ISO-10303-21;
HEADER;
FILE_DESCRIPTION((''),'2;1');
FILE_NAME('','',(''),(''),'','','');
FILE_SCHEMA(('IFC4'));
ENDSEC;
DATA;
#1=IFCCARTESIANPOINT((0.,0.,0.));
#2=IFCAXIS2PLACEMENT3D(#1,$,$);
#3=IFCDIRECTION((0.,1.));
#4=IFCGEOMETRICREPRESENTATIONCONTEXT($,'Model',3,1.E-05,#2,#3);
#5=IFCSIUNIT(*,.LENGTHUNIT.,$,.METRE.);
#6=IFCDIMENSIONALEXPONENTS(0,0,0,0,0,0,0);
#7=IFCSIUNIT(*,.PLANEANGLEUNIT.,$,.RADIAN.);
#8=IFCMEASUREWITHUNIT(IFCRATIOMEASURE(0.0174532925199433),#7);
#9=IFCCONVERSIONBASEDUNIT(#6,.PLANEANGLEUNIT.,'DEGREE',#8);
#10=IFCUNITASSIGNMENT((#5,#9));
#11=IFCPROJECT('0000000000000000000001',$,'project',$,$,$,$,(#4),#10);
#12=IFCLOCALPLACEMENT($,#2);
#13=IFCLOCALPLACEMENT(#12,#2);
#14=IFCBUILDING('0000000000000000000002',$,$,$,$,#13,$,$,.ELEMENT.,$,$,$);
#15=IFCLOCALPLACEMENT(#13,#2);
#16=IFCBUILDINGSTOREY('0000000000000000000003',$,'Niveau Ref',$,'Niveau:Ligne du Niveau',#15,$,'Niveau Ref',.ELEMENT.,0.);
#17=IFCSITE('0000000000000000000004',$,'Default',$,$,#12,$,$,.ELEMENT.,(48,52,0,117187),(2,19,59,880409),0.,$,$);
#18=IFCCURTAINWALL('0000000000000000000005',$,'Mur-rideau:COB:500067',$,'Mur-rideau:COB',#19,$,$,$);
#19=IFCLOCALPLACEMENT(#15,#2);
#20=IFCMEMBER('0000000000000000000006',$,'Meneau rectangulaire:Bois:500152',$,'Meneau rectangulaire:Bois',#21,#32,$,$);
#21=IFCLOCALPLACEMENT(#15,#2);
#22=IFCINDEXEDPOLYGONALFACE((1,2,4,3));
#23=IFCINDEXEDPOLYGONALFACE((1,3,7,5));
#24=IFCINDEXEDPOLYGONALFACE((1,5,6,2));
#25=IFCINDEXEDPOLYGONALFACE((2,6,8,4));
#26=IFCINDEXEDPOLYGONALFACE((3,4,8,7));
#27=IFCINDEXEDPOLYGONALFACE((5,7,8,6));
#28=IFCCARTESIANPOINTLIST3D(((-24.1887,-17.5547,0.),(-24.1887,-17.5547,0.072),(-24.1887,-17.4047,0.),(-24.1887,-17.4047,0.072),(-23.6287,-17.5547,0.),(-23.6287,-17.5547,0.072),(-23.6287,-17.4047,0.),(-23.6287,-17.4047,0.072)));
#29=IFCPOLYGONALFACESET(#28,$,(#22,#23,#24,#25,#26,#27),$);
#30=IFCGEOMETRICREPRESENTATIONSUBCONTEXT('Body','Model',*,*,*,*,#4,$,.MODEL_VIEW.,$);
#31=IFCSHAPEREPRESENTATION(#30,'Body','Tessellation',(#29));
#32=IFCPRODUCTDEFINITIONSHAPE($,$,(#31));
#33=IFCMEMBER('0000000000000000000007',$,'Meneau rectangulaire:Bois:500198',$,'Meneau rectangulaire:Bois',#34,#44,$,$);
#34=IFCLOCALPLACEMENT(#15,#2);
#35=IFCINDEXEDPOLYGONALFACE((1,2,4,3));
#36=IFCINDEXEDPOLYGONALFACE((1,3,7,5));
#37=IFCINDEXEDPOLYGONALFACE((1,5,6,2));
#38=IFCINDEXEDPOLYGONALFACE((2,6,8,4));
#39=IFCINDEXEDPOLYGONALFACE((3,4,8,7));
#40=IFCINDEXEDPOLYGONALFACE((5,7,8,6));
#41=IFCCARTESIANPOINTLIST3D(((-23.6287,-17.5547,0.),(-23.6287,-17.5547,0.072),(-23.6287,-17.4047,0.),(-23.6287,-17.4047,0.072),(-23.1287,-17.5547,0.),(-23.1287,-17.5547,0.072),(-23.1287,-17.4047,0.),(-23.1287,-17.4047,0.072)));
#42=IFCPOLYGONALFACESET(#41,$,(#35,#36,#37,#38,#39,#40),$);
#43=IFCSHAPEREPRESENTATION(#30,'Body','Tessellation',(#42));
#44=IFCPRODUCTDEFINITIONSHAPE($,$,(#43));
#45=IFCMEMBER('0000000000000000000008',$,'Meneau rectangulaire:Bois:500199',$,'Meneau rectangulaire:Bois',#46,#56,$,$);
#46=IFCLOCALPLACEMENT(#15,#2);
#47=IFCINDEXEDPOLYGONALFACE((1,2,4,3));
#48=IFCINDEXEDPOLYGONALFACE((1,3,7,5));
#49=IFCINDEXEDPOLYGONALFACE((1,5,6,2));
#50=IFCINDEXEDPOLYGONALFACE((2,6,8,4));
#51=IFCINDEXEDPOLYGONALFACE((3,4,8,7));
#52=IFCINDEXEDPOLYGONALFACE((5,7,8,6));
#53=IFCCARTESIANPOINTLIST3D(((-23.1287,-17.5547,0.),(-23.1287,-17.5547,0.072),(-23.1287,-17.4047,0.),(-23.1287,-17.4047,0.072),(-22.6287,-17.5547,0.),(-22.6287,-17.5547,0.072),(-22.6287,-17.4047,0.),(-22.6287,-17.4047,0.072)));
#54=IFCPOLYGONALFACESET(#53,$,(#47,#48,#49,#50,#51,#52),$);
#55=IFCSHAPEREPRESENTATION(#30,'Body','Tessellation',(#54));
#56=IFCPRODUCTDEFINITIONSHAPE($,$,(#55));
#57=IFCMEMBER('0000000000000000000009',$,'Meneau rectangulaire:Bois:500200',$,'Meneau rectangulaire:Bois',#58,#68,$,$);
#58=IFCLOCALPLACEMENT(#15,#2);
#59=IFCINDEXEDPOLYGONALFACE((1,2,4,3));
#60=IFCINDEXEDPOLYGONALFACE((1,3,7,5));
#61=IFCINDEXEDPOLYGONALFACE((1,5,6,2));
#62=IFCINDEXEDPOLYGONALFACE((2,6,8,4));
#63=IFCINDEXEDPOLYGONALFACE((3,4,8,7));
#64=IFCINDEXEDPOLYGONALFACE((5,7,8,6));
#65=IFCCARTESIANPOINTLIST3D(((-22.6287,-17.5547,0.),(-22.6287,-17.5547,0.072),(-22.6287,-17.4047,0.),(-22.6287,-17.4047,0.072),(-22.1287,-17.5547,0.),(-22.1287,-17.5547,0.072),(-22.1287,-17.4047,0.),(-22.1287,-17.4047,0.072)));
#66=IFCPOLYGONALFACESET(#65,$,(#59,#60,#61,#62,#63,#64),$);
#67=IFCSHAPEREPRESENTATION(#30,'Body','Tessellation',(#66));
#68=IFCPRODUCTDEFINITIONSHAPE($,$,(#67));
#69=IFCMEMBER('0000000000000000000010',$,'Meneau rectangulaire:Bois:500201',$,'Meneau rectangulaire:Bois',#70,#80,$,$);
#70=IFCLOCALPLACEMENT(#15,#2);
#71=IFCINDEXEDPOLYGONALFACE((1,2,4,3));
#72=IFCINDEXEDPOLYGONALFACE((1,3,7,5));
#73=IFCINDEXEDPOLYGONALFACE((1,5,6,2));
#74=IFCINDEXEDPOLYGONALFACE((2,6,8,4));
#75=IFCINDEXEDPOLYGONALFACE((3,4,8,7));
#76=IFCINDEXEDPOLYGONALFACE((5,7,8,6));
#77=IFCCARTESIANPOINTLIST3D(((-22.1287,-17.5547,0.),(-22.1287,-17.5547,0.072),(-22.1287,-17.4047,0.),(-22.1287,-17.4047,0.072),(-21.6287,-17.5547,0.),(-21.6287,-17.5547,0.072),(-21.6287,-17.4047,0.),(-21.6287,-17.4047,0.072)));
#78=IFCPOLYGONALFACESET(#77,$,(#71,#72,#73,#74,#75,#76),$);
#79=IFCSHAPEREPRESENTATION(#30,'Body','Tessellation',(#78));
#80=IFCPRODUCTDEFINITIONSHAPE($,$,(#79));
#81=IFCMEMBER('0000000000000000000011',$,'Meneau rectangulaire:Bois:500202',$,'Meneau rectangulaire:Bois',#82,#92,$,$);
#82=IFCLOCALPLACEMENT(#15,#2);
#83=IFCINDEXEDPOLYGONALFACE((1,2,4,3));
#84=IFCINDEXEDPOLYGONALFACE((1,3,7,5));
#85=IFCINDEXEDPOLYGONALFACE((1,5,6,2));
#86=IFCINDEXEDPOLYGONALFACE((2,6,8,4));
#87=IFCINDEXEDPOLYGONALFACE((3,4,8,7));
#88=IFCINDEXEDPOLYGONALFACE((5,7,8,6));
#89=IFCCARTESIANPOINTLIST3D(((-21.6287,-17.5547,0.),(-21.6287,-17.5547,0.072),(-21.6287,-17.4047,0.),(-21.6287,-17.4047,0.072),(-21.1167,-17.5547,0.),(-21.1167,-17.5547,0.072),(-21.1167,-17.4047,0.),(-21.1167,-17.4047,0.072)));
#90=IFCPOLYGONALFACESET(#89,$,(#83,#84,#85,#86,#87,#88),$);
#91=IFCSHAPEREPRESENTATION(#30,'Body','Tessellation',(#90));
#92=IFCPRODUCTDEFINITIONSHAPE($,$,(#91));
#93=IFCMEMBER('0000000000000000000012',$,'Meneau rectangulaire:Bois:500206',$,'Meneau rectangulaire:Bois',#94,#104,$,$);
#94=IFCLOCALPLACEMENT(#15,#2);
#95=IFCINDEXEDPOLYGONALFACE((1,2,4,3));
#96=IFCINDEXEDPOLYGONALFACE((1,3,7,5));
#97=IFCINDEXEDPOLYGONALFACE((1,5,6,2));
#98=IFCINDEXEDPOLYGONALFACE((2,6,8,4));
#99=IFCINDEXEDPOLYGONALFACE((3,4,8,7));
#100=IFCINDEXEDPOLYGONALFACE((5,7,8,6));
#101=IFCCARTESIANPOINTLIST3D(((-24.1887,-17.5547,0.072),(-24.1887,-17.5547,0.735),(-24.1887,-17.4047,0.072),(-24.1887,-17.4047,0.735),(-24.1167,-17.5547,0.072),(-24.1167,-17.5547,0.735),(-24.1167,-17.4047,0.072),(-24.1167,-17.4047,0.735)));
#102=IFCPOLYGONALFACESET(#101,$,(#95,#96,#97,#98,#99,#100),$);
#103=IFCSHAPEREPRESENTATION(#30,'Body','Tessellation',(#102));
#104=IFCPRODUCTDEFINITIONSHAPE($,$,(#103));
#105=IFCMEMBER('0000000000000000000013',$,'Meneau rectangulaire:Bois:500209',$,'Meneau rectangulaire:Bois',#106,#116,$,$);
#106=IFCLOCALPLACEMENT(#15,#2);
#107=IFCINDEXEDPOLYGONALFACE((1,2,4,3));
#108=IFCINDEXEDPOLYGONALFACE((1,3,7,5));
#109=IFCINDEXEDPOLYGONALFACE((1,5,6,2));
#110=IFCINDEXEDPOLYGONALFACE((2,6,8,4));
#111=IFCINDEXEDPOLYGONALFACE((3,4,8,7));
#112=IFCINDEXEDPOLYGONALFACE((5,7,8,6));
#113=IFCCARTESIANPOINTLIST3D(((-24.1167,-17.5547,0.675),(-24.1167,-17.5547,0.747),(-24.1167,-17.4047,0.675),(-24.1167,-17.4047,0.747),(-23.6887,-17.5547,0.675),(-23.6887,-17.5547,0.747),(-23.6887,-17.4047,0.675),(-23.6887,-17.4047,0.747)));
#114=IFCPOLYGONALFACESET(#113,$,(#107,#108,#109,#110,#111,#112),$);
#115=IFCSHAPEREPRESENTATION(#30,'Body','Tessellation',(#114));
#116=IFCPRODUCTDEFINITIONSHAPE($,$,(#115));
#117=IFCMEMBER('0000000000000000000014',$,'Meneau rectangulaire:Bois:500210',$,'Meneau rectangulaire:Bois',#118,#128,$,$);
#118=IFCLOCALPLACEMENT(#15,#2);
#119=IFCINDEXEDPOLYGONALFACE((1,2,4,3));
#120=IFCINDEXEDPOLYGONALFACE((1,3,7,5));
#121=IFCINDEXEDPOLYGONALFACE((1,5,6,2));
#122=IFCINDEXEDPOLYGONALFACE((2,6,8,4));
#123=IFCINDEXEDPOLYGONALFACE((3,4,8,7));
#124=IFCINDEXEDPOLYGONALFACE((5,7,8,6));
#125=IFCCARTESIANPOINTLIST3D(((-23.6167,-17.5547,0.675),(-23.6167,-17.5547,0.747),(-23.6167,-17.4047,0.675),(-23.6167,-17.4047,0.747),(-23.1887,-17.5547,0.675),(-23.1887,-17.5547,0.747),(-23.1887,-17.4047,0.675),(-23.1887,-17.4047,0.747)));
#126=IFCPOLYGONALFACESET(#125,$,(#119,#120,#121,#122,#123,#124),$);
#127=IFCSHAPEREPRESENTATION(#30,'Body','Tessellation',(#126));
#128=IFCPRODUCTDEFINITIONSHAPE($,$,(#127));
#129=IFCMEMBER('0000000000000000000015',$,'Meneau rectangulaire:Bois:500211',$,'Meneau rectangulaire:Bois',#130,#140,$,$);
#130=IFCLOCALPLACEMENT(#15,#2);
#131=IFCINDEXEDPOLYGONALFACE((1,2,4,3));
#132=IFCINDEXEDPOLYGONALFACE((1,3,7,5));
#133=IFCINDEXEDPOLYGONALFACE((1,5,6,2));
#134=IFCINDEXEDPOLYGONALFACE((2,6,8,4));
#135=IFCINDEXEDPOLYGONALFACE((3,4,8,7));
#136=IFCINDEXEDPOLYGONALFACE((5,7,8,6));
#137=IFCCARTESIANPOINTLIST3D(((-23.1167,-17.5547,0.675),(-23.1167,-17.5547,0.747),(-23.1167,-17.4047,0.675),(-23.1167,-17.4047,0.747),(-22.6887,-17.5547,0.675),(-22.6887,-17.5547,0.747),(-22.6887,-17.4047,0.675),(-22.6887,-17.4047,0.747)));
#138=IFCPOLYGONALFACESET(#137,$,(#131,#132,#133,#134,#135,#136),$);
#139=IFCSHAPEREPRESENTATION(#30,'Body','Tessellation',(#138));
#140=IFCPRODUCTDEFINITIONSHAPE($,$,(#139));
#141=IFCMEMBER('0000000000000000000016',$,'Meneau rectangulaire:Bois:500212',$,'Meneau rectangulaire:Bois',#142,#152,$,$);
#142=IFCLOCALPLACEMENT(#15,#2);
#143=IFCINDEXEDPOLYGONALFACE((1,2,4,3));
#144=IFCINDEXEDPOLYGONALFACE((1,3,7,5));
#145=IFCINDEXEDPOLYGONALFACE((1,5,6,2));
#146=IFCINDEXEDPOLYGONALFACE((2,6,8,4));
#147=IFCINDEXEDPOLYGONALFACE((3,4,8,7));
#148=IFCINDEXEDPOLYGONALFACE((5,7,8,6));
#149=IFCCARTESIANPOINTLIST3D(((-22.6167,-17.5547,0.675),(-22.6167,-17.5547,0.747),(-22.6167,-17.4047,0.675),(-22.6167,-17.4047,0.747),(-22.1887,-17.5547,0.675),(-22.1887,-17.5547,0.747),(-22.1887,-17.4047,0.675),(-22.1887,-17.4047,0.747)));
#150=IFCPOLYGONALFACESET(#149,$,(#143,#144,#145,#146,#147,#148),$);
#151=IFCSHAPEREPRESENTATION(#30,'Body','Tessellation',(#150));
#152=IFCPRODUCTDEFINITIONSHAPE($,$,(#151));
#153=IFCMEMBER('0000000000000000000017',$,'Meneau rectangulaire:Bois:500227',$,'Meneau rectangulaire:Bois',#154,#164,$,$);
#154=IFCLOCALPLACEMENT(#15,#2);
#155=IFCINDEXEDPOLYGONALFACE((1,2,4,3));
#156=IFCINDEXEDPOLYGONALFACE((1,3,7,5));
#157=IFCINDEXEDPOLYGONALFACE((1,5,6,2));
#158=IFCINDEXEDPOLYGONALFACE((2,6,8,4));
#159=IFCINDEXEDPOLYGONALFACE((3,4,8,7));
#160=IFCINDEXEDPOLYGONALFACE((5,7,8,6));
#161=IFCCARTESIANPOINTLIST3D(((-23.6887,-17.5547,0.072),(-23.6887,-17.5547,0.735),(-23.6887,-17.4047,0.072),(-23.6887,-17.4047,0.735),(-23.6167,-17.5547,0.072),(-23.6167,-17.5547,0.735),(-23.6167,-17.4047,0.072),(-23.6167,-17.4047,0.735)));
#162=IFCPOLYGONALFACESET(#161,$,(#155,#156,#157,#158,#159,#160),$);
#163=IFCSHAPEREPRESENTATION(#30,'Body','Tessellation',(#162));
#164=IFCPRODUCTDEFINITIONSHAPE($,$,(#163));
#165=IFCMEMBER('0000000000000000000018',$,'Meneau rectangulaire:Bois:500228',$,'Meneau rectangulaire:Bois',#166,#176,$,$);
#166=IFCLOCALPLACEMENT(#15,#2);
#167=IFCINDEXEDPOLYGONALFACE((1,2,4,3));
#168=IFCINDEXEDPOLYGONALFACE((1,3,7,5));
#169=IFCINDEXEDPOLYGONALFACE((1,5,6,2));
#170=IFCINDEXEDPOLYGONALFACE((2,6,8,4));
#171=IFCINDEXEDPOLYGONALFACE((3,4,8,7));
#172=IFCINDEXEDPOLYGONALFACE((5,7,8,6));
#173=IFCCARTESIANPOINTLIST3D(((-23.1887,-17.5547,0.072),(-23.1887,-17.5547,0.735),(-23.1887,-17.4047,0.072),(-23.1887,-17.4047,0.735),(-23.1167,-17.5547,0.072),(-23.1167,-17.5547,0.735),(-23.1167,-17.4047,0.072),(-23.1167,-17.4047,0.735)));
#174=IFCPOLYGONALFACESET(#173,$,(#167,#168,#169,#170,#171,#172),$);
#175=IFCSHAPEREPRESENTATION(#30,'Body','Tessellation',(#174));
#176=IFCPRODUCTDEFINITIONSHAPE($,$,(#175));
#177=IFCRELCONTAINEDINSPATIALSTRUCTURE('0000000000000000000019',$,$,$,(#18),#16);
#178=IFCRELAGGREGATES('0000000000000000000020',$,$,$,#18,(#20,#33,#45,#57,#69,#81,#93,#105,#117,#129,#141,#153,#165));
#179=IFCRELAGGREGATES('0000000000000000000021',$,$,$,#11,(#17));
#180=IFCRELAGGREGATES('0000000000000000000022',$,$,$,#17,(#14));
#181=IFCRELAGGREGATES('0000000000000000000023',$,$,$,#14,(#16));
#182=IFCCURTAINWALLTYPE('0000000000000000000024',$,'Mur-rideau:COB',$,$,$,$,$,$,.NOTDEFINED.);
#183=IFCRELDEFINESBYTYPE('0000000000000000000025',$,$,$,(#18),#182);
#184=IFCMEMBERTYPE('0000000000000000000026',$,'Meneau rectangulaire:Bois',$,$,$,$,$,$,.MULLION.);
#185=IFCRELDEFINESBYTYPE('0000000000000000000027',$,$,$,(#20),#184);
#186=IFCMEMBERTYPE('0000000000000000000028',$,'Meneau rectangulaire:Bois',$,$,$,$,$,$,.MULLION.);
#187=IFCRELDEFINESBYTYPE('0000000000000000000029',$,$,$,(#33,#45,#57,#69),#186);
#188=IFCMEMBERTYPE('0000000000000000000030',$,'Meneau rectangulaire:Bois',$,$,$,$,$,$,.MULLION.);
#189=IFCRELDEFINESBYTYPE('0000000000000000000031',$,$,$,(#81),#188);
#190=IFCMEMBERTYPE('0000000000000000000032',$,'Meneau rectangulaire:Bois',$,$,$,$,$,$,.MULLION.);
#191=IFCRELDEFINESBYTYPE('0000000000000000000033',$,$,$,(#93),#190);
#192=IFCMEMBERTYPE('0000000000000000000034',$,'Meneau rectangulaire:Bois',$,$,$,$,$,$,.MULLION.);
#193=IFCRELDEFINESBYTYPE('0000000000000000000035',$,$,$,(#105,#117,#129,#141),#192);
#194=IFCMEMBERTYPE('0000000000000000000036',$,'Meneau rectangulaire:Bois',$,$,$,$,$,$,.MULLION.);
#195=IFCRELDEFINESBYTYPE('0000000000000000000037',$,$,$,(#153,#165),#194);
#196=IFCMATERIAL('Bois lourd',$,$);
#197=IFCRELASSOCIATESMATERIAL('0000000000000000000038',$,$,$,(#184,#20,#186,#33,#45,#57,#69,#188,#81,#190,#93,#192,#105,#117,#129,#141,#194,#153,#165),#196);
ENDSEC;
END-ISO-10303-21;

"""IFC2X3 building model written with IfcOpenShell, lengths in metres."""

from ifc_helpers import new_model, entity, si_unit, converted_unit, direction, frame, origin, origin_2d_with_axis, place, context, subcontext, project, spatial, rectangle, extrude, source, transform, mapped, material, type_object, type_shapes, element, aggregate, save


model = new_model("IFC2X3")

# Units and contexts
model_context = context("Model", 3, precision=1e-05, world=origin(), true_north=direction((0.0, 1.0)))
body_context = subcontext(model_context, "Body", "Model", "MODEL_VIEW")
ifc_project = project(units=[si_unit("LENGTHUNIT", "METRE"), converted_unit("PLANEANGLEUNIT", "DEGREE", entity("IfcRatioMeasure", 0.0174532925199433), si_unit("PLANEANGLEUNIT", "RADIAN"), dimensions=[0, 0, 0, 0, 0, 0, 0])], contexts=[model_context])

# Site, building, storey
site_placement = place(None, origin())
site = spatial("IfcSite", under=ifc_project, at=site_placement, Name="Default", CompositionType="ELEMENT", RefLatitude=(48, 52, 0, 117187), RefLongitude=(2, 19, 59, 880409), RefElevation=0.0)
building_placement = place(site_placement, origin())
building = spatial("IfcBuilding", under=site, at=building_placement, CompositionType="ELEMENT")
storey_placement = place(building_placement, origin())
storey = spatial("IfcBuildingStorey", under=building, at=storey_placement, Name="Niveau Ref", ObjectType="Niveau:Ligne du Niveau", LongName="Niveau Ref", CompositionType="ELEMENT", Elevation=0.0)

# Curtain wall, members
curtain_wall_type_1 = type_object("IfcCurtainWallType", Name="Mur-rideau:COB", PredefinedType="NOTDEFINED")
curtain_wall_1_placement = place(storey_placement, origin())
curtain_wall_1 = element("IfcCurtainWall", 1, at=curtain_wall_1_placement, inside=storey, type_object=curtain_wall_type_1, Name="Mur-rideau:COB:500067", ObjectType="Mur-rideau:COB")
ifc_material_1 = material(Name="Bois lourd")
member_type_1 = type_object("IfcMemberType", Name="Meneau rectangulaire:Bois", PredefinedType="MULLION", material=ifc_material_1)
shared_shape_1 = source(origin(), body_context, "Body", "SweptSolid", [
    extrude(rectangle(XDim=0.15, YDim=0.072, at=origin_2d_with_axis()), frame((-0.036, 0.0, -0.56), z_axis=(0.0, 0.0, 1.0), x_axis=(0.0, -1.0, 0.0)), (0.0, 0.0, 1.0), 0.56),
])
type_shapes(member_type_1, [shared_shape_1])
member_1_placement = place(storey_placement, frame((-24.1887, -17.4797, 0.0), z_axis=(-1.0, 0.0, 0.0), x_axis=(0.0, 0.0, -1.0)))
member_1 = element("IfcMember", 2, at=member_1_placement, type_object=member_type_1, material=ifc_material_1, Name="Meneau rectangulaire:Bois:500152", ObjectType="Meneau rectangulaire:Bois", context=body_context, shape_type="MappedRepresentation", body=[
    mapped(shared_shape_1, transform((0.0, 0.0, 0.0), scale=1.0)),
])
member_type_2 = type_object("IfcMemberType", Name="Meneau rectangulaire:Bois", PredefinedType="MULLION", material=ifc_material_1)
shared_shape_2 = source(origin(), body_context, "Body", "SweptSolid", [
    extrude(rectangle(XDim=0.15, YDim=0.072, at=origin_2d_with_axis()), frame((-0.036, 0.0, -0.5), z_axis=(0.0, 0.0, 1.0), x_axis=(0.0, -1.0, 0.0)), (0.0, 0.0, 1.0), 0.5),
])
type_shapes(member_type_2, [shared_shape_2])
member_2_placement = place(storey_placement, frame((-23.6287, -17.4797, 0.0), z_axis=(-1.0, 0.0, 0.0), x_axis=(0.0, 0.0, -1.0)))
member_2 = element("IfcMember", 3, at=member_2_placement, type_object=member_type_2, material=ifc_material_1, Name="Meneau rectangulaire:Bois:500198", ObjectType="Meneau rectangulaire:Bois", context=body_context, shape_type="MappedRepresentation", body=[
    mapped(shared_shape_2, transform((0.0, 0.0, 0.0), scale=1.0)),
])
member_3_placement = place(storey_placement, frame((-23.1287, -17.4797, 0.0), z_axis=(-1.0, 0.0, 0.0), x_axis=(0.0, 0.0, -1.0)))
member_3 = element("IfcMember", 4, at=member_3_placement, type_object=member_type_2, material=ifc_material_1, Name="Meneau rectangulaire:Bois:500199", ObjectType="Meneau rectangulaire:Bois", context=body_context, shape_type="MappedRepresentation", body=[
    mapped(shared_shape_2, transform((0.0, 0.0, 0.0), scale=1.0)),
])
member_4_placement = place(storey_placement, frame((-22.6287, -17.4797, 0.0), z_axis=(-1.0, 0.0, 0.0), x_axis=(0.0, 0.0, -1.0)))
member_4 = element("IfcMember", 5, at=member_4_placement, type_object=member_type_2, material=ifc_material_1, Name="Meneau rectangulaire:Bois:500200", ObjectType="Meneau rectangulaire:Bois", context=body_context, shape_type="MappedRepresentation", body=[
    mapped(shared_shape_2, transform((0.0, 0.0, 0.0), scale=1.0)),
])
member_5_placement = place(storey_placement, frame((-22.1287, -17.4797, 0.0), z_axis=(-1.0, 0.0, 0.0), x_axis=(0.0, 0.0, -1.0)))
member_5 = element("IfcMember", 6, at=member_5_placement, type_object=member_type_2, material=ifc_material_1, Name="Meneau rectangulaire:Bois:500201", ObjectType="Meneau rectangulaire:Bois", context=body_context, shape_type="MappedRepresentation", body=[
    mapped(shared_shape_2, transform((0.0, 0.0, 0.0), scale=1.0)),
])
member_type_3 = type_object("IfcMemberType", Name="Meneau rectangulaire:Bois", PredefinedType="MULLION", material=ifc_material_1)
shared_shape_3 = source(origin(), body_context, "Body", "SweptSolid", [
    extrude(rectangle(XDim=0.15, YDim=0.072, at=origin_2d_with_axis()), frame((-0.036, 0.0, -0.512), z_axis=(0.0, 0.0, 1.0), x_axis=(0.0, -1.0, 0.0)), (0.0, 0.0, 1.0), 0.512),
])
type_shapes(member_type_3, [shared_shape_3])
member_6_placement = place(storey_placement, frame((-21.6287, -17.4797, 0.0), z_axis=(-1.0, 0.0, 0.0), x_axis=(0.0, 0.0, -1.0)))
member_6 = element("IfcMember", 7, at=member_6_placement, type_object=member_type_3, material=ifc_material_1, Name="Meneau rectangulaire:Bois:500202", ObjectType="Meneau rectangulaire:Bois", context=body_context, shape_type="MappedRepresentation", body=[
    mapped(shared_shape_3, transform((0.0, 0.0, 0.0), scale=1.0)),
])
member_type_4 = type_object("IfcMemberType", Name="Meneau rectangulaire:Bois", PredefinedType="MULLION", material=ifc_material_1)
shared_shape_4 = source(origin(), body_context, "Body", "SweptSolid", [
    extrude(rectangle(XDim=0.15, YDim=0.072, at=origin_2d_with_axis()), frame((-0.036, 0.0, -0.663), z_axis=(0.0, 0.0, 1.0), x_axis=(0.0, -1.0, 0.0)), (0.0, 0.0, 1.0), 0.663),
])
type_shapes(member_type_4, [shared_shape_4])
member_7_placement = place(storey_placement, frame((-24.1887, -17.4797, 0.735), z_axis=(0.0, 0.0, 1.0), x_axis=(-1.0, 0.0, 0.0)))
member_7 = element("IfcMember", 8, at=member_7_placement, type_object=member_type_4, material=ifc_material_1, Name="Meneau rectangulaire:Bois:500206", ObjectType="Meneau rectangulaire:Bois", context=body_context, shape_type="MappedRepresentation", body=[
    mapped(shared_shape_4, transform((0.0, 0.0, 0.0), scale=1.0)),
])
member_type_5 = type_object("IfcMemberType", Name="Meneau rectangulaire:Bois", PredefinedType="MULLION", material=ifc_material_1)
shared_shape_5 = source(origin(), body_context, "Body", "SweptSolid", [
    extrude(rectangle(XDim=0.15, YDim=0.072, at=origin_2d_with_axis()), frame((-0.024, 0.0, -0.428), z_axis=(0.0, 0.0, 1.0), x_axis=(0.0, -1.0, 0.0)), (0.0, 0.0, 1.0), 0.428),
])
type_shapes(member_type_5, [shared_shape_5])
member_8_placement = place(storey_placement, frame((-23.6887, -17.4797, 0.735), z_axis=(1.0, 0.0, 0.0), x_axis=(0.0, 0.0, 1.0)))
member_8 = element("IfcMember", 9, at=member_8_placement, type_object=member_type_5, material=ifc_material_1, Name="Meneau rectangulaire:Bois:500209", ObjectType="Meneau rectangulaire:Bois", context=body_context, shape_type="MappedRepresentation", body=[
    mapped(shared_shape_5, transform((0.0, 0.0, 0.0), scale=1.0)),
])
member_9_placement = place(storey_placement, frame((-23.1887, -17.4797, 0.735), z_axis=(1.0, 0.0, 0.0), x_axis=(0.0, 0.0, 1.0)))
member_9 = element("IfcMember", 10, at=member_9_placement, type_object=member_type_5, material=ifc_material_1, Name="Meneau rectangulaire:Bois:500210", ObjectType="Meneau rectangulaire:Bois", context=body_context, shape_type="MappedRepresentation", body=[
    mapped(shared_shape_5, transform((0.0, 0.0, 0.0), scale=1.0)),
])
member_10_placement = place(storey_placement, frame((-22.6887, -17.4797, 0.735), z_axis=(1.0, 0.0, 0.0), x_axis=(0.0, 0.0, 1.0)))
member_10 = element("IfcMember", 11, at=member_10_placement, type_object=member_type_5, material=ifc_material_1, Name="Meneau rectangulaire:Bois:500211", ObjectType="Meneau rectangulaire:Bois", context=body_context, shape_type="MappedRepresentation", body=[
    mapped(shared_shape_5, transform((0.0, 0.0, 0.0), scale=1.0)),
])
member_11_placement = place(storey_placement, frame((-22.1887, -17.4797, 0.735), z_axis=(1.0, 0.0, 0.0), x_axis=(0.0, 0.0, 1.0)))
member_11 = element("IfcMember", 12, at=member_11_placement, type_object=member_type_5, material=ifc_material_1, Name="Meneau rectangulaire:Bois:500212", ObjectType="Meneau rectangulaire:Bois", context=body_context, shape_type="MappedRepresentation", body=[
    mapped(shared_shape_5, transform((0.0, 0.0, 0.0), scale=1.0)),
])
member_type_6 = type_object("IfcMemberType", Name="Meneau rectangulaire:Bois", PredefinedType="MULLION", material=ifc_material_1)
shared_shape_6 = source(origin(), body_context, "Body", "SweptSolid", [
    extrude(rectangle(XDim=0.15, YDim=0.072, at=origin_2d_with_axis()), frame((-0.024, 0.0, -0.663), z_axis=(0.0, 0.0, 1.0), x_axis=(0.0, -1.0, 0.0)), (0.0, 0.0, 1.0), 0.663),
])
type_shapes(member_type_6, [shared_shape_6])
member_12_placement = place(storey_placement, frame((-23.6287, -17.4797, 0.072), z_axis=(0.0, 0.0, -1.0), x_axis=(1.0, 0.0, 0.0)))
member_12 = element("IfcMember", 13, at=member_12_placement, type_object=member_type_6, material=ifc_material_1, Name="Meneau rectangulaire:Bois:500227", ObjectType="Meneau rectangulaire:Bois", context=body_context, shape_type="MappedRepresentation", body=[
    mapped(shared_shape_6, transform((0.0, 0.0, 0.0), scale=1.0)),
])
member_13_placement = place(storey_placement, frame((-23.1287, -17.4797, 0.072), z_axis=(0.0, 0.0, -1.0), x_axis=(1.0, 0.0, 0.0)))
member_13 = element("IfcMember", 14, at=member_13_placement, type_object=member_type_6, material=ifc_material_1, Name="Meneau rectangulaire:Bois:500228", ObjectType="Meneau rectangulaire:Bois", context=body_context, shape_type="MappedRepresentation", body=[
    mapped(shared_shape_6, transform((0.0, 0.0, 0.0), scale=1.0)),
])
aggregate(curtain_wall_1, [member_1, member_2, member_3, member_4, member_5, member_6, member_7, member_8, member_9, member_10, member_11, member_12, member_13])

save(model, "model.ifc")
